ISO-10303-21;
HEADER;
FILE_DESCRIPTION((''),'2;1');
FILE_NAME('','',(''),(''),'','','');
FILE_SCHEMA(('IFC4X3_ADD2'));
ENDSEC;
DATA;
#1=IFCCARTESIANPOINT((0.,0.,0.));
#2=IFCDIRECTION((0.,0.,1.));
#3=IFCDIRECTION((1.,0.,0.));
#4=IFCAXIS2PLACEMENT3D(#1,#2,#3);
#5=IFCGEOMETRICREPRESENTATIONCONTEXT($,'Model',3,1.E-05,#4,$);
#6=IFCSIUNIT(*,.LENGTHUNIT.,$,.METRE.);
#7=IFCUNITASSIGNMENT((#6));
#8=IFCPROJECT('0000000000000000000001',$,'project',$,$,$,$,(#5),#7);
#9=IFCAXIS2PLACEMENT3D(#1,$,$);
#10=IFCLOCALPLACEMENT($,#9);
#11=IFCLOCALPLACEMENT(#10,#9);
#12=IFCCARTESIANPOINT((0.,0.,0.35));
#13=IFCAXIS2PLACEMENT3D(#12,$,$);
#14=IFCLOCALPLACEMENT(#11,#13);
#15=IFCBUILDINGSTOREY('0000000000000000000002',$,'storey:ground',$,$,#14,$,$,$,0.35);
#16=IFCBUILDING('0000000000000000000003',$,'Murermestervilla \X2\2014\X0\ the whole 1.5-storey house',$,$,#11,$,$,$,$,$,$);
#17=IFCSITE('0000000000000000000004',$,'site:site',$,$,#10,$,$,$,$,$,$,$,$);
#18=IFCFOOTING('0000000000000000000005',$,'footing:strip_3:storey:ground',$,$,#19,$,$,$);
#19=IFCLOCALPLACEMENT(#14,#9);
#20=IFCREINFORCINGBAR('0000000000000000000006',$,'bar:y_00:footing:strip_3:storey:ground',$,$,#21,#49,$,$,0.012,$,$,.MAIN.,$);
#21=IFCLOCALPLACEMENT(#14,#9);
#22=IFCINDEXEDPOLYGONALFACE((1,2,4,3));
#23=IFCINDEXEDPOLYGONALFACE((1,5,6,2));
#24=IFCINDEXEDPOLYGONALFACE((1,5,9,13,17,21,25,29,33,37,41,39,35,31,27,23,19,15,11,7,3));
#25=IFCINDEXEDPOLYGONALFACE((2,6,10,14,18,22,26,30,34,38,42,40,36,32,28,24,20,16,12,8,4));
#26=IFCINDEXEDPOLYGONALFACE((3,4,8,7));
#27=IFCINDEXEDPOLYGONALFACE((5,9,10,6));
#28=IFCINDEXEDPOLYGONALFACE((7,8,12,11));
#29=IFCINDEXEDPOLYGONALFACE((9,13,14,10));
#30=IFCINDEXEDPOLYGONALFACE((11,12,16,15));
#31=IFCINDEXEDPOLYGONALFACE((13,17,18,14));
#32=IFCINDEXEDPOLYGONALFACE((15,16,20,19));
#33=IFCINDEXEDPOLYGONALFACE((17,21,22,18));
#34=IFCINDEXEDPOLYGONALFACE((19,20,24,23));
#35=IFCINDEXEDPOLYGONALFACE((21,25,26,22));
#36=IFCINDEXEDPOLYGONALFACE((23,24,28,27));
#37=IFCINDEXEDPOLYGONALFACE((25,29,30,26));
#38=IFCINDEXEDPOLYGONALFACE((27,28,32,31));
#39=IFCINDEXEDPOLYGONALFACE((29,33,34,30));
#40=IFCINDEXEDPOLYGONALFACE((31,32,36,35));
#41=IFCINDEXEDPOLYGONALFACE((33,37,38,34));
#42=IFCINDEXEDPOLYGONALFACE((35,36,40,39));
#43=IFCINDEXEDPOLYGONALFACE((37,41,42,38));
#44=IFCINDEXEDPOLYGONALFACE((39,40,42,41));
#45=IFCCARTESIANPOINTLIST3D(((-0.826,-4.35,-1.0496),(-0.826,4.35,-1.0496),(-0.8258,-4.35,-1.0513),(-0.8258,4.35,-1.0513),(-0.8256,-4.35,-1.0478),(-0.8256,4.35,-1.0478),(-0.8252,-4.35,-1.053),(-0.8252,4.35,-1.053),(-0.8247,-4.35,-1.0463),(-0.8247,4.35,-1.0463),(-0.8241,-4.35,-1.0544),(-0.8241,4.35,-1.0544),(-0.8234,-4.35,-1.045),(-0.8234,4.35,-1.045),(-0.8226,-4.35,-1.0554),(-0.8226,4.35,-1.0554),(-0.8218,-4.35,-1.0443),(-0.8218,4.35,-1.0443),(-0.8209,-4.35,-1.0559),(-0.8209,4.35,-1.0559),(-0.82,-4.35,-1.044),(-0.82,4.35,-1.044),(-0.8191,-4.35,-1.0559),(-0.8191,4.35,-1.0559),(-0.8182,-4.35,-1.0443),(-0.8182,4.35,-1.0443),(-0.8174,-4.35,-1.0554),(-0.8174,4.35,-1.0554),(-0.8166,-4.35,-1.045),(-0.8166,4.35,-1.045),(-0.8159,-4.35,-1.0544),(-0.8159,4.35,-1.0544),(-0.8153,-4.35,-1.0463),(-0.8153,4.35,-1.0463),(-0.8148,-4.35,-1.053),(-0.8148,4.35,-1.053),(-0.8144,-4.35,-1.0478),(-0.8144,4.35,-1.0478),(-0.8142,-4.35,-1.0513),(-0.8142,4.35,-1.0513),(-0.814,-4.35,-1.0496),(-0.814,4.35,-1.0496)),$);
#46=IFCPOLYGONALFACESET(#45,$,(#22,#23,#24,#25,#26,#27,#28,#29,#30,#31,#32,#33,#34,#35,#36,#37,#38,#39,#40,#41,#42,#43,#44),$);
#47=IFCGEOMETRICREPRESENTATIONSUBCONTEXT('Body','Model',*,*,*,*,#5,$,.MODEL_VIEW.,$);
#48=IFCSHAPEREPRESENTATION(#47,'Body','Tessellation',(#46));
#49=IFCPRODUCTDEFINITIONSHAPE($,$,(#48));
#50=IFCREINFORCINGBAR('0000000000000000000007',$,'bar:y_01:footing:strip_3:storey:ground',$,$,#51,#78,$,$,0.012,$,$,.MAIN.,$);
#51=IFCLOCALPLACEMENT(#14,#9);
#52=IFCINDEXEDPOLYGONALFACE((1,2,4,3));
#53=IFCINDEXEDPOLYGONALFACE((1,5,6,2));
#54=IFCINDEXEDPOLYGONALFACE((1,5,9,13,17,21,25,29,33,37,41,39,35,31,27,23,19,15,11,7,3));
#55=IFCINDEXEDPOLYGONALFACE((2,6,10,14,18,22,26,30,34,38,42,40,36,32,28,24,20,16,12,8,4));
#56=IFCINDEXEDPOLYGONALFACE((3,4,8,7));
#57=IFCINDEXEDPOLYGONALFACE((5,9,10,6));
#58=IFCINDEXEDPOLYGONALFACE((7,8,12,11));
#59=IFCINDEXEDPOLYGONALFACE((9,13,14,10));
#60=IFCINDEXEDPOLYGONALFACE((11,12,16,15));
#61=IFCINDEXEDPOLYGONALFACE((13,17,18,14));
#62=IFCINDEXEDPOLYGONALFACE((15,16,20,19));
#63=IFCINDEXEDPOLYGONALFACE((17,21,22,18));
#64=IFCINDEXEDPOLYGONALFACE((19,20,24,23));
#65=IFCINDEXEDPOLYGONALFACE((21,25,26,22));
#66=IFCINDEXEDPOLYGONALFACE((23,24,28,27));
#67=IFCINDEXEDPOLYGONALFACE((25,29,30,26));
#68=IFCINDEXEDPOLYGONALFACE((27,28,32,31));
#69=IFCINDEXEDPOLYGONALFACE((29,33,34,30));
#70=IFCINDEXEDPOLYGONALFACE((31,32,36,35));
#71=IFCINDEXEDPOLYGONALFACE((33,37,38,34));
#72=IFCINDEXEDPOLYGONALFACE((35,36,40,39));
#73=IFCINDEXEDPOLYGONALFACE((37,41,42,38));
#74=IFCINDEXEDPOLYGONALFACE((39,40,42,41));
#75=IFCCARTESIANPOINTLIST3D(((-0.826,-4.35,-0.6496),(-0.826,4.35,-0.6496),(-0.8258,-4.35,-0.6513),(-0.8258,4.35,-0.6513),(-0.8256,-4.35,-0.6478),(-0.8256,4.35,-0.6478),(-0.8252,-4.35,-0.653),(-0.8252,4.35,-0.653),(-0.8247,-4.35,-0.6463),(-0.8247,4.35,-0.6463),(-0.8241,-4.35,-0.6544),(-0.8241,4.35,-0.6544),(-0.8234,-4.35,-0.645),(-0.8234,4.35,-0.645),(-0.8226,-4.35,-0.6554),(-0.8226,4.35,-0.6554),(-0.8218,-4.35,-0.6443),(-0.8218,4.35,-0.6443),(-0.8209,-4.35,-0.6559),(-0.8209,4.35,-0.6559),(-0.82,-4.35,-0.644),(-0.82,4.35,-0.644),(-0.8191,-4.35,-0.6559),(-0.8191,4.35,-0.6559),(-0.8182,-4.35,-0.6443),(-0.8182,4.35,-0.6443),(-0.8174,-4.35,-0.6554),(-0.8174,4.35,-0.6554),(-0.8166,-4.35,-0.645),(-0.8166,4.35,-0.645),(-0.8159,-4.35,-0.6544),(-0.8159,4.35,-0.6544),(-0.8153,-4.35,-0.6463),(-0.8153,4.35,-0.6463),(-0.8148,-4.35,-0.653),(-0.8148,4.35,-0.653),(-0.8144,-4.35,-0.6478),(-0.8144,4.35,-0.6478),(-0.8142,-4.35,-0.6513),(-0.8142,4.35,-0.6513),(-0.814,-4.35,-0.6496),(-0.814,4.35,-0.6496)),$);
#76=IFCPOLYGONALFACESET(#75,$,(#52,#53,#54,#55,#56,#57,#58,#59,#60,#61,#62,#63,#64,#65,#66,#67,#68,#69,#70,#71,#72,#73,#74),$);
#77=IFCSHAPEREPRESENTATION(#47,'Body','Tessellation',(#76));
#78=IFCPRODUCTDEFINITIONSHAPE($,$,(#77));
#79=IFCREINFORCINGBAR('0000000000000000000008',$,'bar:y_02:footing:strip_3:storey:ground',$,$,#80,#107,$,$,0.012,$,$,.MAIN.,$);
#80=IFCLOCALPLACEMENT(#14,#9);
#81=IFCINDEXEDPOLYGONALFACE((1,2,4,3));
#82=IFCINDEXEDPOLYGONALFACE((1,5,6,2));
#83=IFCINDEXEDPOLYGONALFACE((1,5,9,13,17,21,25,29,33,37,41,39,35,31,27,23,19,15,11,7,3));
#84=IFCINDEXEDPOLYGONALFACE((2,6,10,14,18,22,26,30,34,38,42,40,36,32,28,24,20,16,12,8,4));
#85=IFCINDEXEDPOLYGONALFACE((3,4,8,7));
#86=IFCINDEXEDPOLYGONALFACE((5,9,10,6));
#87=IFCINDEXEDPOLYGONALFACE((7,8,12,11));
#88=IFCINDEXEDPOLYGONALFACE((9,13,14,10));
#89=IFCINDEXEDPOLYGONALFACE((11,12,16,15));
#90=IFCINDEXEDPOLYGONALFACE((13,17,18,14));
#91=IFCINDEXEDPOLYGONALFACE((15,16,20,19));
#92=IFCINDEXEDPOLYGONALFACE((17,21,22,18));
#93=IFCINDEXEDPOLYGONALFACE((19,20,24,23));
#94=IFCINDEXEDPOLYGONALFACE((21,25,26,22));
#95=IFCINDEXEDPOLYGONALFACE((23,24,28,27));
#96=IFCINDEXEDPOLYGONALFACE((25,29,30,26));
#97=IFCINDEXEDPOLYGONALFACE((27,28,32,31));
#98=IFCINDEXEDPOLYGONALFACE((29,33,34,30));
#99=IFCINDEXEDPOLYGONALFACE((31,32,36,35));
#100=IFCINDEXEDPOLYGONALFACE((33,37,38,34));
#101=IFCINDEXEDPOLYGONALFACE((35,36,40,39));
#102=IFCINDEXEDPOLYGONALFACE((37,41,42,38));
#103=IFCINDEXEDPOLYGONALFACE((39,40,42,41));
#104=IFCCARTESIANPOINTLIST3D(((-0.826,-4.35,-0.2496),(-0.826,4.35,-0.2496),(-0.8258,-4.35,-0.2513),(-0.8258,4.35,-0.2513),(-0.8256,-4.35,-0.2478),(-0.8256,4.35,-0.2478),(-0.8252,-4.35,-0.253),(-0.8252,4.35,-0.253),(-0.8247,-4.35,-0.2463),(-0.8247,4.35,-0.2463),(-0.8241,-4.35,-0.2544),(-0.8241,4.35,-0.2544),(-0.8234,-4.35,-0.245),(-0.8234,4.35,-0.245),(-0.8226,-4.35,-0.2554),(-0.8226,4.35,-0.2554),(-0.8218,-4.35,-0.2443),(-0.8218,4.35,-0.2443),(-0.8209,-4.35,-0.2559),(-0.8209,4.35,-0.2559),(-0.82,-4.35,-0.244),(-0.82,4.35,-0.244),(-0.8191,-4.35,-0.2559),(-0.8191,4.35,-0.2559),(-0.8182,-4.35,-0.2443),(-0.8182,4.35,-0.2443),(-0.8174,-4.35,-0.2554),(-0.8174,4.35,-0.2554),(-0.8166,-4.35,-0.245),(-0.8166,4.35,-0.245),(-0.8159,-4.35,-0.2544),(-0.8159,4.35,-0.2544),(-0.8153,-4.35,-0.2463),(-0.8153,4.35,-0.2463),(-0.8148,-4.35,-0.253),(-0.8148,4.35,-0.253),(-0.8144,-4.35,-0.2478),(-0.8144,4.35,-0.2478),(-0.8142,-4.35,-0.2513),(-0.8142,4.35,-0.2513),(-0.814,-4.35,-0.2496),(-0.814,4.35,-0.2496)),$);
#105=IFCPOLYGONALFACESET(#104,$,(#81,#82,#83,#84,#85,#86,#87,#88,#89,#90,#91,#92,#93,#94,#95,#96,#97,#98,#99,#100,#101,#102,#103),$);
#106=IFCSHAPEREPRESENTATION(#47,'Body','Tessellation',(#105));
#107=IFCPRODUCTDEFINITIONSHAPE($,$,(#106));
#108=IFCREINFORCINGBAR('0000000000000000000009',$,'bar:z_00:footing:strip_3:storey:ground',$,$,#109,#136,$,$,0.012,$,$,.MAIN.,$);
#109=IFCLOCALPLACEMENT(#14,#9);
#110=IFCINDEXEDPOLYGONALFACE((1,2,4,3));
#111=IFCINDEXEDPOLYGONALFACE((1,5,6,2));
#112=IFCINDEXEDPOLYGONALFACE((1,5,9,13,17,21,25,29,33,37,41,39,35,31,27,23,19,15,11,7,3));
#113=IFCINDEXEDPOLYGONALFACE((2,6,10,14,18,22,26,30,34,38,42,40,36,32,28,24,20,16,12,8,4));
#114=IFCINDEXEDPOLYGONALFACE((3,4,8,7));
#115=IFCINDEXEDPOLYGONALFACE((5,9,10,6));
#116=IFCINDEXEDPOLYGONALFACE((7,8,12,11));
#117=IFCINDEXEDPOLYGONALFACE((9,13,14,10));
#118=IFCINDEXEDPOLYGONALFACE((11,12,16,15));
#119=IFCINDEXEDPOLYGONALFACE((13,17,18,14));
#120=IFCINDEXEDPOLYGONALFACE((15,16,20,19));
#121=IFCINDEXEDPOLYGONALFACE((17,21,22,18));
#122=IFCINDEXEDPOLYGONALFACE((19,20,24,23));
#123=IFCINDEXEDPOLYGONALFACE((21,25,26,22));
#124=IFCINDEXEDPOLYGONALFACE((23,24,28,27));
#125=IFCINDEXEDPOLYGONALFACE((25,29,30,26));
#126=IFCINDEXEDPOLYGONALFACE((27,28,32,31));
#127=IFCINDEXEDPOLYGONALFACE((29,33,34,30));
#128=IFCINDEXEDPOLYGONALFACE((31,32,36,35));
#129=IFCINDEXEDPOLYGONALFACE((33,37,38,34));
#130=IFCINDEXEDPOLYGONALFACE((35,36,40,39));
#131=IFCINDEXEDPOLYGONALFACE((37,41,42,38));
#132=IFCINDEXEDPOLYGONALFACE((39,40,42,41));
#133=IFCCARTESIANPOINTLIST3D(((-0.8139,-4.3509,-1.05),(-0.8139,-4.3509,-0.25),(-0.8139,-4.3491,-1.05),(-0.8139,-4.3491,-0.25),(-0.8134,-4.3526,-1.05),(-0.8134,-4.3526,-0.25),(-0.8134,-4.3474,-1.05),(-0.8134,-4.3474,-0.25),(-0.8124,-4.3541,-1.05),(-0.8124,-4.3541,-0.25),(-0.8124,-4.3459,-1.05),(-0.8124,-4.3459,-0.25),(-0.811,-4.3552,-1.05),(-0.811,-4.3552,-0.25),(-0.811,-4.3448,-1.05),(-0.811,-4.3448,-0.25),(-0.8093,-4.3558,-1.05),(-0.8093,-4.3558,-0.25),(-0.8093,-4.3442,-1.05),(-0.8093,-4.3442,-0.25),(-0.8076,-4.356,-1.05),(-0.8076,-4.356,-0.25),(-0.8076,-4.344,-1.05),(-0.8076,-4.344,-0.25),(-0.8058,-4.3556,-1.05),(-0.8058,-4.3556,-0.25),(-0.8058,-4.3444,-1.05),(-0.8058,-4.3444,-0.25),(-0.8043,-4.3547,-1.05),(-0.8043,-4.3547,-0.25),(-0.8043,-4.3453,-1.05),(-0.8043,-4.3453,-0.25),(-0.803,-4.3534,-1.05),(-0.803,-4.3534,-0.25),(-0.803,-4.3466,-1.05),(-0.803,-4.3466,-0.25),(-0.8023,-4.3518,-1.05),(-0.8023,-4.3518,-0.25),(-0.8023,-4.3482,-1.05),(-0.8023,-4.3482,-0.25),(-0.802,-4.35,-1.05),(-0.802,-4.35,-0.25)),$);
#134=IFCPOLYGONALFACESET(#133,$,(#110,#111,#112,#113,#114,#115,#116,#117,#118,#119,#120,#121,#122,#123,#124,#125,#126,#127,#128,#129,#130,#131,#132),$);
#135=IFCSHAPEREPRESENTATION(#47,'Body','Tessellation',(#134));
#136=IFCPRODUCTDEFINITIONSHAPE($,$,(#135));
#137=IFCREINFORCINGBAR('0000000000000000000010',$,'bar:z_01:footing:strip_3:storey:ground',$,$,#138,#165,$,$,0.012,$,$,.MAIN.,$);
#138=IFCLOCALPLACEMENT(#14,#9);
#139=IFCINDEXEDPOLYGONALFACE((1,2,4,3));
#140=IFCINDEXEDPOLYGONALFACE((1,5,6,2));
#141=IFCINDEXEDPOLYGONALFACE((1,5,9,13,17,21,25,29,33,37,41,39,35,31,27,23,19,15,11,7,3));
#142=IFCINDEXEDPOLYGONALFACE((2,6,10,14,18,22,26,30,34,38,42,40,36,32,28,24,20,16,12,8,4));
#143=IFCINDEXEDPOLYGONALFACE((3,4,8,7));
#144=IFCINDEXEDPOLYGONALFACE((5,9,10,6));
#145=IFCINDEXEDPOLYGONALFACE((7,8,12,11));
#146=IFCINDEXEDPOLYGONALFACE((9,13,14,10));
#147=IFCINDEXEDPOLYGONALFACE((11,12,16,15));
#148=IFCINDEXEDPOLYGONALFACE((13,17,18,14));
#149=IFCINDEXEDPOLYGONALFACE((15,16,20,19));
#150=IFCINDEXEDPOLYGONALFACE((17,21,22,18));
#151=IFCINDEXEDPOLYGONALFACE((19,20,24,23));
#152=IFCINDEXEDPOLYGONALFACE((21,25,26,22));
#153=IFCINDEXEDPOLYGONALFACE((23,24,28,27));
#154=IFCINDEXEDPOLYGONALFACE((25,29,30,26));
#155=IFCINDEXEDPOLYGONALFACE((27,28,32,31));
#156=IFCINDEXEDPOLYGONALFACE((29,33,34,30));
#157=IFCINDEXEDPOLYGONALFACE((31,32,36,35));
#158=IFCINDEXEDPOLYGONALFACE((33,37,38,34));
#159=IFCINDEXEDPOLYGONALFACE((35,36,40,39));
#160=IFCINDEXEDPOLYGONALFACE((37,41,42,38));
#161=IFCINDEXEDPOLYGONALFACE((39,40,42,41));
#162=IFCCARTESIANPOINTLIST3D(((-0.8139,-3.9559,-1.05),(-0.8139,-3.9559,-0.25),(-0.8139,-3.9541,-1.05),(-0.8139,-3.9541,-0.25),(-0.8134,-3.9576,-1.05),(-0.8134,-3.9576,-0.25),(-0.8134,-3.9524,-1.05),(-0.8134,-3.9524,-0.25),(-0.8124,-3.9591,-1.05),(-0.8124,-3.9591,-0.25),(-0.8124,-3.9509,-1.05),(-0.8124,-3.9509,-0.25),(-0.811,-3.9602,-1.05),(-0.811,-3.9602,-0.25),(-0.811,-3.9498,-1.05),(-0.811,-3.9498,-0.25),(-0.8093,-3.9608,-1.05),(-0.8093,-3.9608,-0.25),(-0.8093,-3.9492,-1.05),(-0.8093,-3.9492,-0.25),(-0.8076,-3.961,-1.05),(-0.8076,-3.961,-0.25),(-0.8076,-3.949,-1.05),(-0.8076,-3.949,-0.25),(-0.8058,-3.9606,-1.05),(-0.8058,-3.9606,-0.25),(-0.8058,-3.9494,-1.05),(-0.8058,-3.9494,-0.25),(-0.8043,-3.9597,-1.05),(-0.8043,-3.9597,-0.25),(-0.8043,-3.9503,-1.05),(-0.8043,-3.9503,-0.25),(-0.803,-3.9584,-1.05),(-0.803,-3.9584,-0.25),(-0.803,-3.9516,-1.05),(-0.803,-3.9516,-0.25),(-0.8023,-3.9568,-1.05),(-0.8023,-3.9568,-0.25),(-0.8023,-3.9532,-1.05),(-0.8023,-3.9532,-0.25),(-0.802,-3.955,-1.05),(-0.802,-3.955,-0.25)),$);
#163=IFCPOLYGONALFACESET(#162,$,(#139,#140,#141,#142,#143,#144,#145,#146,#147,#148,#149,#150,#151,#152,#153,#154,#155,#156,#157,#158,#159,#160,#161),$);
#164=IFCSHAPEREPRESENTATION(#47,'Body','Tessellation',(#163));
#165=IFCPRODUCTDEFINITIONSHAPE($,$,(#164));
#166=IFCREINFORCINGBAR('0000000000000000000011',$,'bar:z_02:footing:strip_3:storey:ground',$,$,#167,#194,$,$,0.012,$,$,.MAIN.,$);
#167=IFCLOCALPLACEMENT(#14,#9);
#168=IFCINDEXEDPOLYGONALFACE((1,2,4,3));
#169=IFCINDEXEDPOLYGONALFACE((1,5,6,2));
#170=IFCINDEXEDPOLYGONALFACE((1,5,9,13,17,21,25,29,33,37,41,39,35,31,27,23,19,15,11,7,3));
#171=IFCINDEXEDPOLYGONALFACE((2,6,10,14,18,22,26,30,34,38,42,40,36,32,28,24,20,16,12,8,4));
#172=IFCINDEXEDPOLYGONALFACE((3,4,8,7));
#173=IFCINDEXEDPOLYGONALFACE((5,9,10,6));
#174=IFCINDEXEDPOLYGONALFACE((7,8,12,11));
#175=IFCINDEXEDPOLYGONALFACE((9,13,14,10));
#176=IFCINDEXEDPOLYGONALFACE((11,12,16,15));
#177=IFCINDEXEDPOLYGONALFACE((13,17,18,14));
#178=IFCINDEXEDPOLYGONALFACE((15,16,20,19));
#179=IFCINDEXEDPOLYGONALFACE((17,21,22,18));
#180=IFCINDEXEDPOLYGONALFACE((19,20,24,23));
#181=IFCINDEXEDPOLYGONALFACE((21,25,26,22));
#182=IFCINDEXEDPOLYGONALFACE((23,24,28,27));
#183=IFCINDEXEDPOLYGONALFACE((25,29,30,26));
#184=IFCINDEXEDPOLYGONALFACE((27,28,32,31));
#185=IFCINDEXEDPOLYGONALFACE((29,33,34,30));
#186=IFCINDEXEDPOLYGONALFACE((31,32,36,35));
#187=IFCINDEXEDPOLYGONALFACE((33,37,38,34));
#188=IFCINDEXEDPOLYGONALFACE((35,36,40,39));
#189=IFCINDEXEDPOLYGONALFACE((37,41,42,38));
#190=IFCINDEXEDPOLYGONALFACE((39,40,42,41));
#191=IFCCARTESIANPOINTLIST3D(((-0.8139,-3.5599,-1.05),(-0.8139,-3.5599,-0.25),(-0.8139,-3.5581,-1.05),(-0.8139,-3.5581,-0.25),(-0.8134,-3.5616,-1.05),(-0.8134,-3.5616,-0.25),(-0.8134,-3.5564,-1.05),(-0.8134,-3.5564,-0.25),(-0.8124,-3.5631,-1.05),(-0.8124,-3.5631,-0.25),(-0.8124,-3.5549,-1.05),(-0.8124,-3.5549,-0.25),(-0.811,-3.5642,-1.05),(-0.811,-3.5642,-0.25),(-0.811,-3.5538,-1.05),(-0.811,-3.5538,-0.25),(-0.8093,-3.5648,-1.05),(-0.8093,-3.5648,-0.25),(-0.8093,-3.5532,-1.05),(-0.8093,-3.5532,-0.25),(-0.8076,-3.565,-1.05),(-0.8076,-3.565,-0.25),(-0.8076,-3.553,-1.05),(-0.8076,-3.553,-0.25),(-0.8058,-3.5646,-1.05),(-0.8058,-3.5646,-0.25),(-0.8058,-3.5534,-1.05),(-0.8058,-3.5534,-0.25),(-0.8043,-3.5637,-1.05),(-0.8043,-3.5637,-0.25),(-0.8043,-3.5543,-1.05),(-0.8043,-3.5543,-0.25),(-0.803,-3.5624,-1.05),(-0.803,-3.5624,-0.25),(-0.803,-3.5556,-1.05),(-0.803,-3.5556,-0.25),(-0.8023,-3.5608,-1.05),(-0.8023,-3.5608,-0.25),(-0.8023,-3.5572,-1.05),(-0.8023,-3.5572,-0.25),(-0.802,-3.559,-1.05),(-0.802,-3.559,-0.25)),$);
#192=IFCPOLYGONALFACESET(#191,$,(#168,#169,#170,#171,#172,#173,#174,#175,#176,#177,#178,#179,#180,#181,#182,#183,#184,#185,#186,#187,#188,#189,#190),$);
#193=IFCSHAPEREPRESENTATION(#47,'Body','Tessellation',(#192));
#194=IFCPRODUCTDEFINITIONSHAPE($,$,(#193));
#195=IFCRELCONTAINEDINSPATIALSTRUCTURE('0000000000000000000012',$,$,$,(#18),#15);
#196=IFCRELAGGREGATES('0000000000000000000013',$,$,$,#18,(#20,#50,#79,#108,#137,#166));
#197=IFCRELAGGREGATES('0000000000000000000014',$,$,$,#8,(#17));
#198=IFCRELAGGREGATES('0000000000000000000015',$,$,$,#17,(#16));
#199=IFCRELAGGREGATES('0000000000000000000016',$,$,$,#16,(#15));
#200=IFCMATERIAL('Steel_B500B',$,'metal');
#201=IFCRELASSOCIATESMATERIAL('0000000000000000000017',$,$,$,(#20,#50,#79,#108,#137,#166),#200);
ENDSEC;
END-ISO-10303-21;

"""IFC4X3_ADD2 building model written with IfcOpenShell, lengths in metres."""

from ifc_helpers import new_model, entity, si_unit, frame, origin, origin_with_axes, place, context, subcontext, project, spatial, material, element, aggregate, save


model = new_model("IFC4X3_ADD2")

# Units and contexts
model_context = context("Model", 3, precision=1e-05, world=origin_with_axes())
body_context = subcontext(model_context, "Body", "Model", "MODEL_VIEW")
ifc_project = project(units=[si_unit("LENGTHUNIT", "METRE")], contexts=[model_context])

# Site, building, storey
placement_1 = place(None, origin())
site = spatial("IfcSite", under=ifc_project, at=placement_1, Name="site:site")
building_placement = place(placement_1, origin())
building = spatial("IfcBuilding", under=site, at=building_placement, Name="Murermestervilla — the whole 1.5-storey house")
storey_placement = place(building_placement, frame((0.0, 0.0, 0.35)))
storey = spatial("IfcBuildingStorey", under=building, at=storey_placement, Name="storey:ground", Elevation=0.35)

# Footing, reinforcing bars
placement_2 = place(storey_placement, frame((0.0, 0.0, -0.35)))
ifc_material = material(Name="Steel_B500B", Category="metal")
footing_1 = element("IfcFooting", 1, at=placement_2, inside=storey, Name="footing:strip_3:storey:ground")
reinforcing_bar_1 = element("IfcReinforcingBar", 2, at=placement_1, material=ifc_material, Name="bar:y_00:footing:strip_3:storey:ground", NominalDiameter=0.012, PredefinedType="MAIN", context=body_context, shape_type="AdvancedSweptSolid", body=[
    entity("IfcSweptDiskSolid", entity("IfcPolyline", [entity("IfcCartesianPoint", [-0.82, -4.35, -0.7]), entity("IfcCartesianPoint", [-0.82, 4.35, -0.7])]), 0.006),
])
reinforcing_bar_2 = element("IfcReinforcingBar", 3, at=placement_1, material=ifc_material, Name="bar:y_01:footing:strip_3:storey:ground", NominalDiameter=0.012, PredefinedType="MAIN", context=body_context, shape_type="AdvancedSweptSolid", body=[
    entity("IfcSweptDiskSolid", entity("IfcPolyline", [entity("IfcCartesianPoint", [-0.82, -4.35, -0.3]), entity("IfcCartesianPoint", [-0.82, 4.35, -0.3])]), 0.006),
])
reinforcing_bar_3 = element("IfcReinforcingBar", 4, at=placement_1, material=ifc_material, Name="bar:y_02:footing:strip_3:storey:ground", NominalDiameter=0.012, PredefinedType="MAIN", context=body_context, shape_type="AdvancedSweptSolid", body=[
    entity("IfcSweptDiskSolid", entity("IfcPolyline", [entity("IfcCartesianPoint", [-0.82, -4.35, 0.1]), entity("IfcCartesianPoint", [-0.82, 4.35, 0.1])]), 0.006),
])
reinforcing_bar_4 = element("IfcReinforcingBar", 5, at=placement_1, material=ifc_material, Name="bar:z_00:footing:strip_3:storey:ground", NominalDiameter=0.012, PredefinedType="MAIN", context=body_context, shape_type="AdvancedSweptSolid", body=[
    entity("IfcSweptDiskSolid", entity("IfcPolyline", [entity("IfcCartesianPoint", [-0.808, -4.35, -0.7]), entity("IfcCartesianPoint", [-0.808, -4.35, 0.1])]), 0.006),
])
reinforcing_bar_5 = element("IfcReinforcingBar", 6, at=placement_1, material=ifc_material, Name="bar:z_01:footing:strip_3:storey:ground", NominalDiameter=0.012, PredefinedType="MAIN", context=body_context, shape_type="AdvancedSweptSolid", body=[
    entity("IfcSweptDiskSolid", entity("IfcPolyline", [entity("IfcCartesianPoint", [-0.808, -3.955, -0.7]), entity("IfcCartesianPoint", [-0.808, -3.955, 0.1])]), 0.006),
])
reinforcing_bar_6 = element("IfcReinforcingBar", 7, at=placement_1, material=ifc_material, Name="bar:z_02:footing:strip_3:storey:ground", NominalDiameter=0.012, PredefinedType="MAIN", context=body_context, shape_type="AdvancedSweptSolid", body=[
    entity("IfcSweptDiskSolid", entity("IfcPolyline", [entity("IfcCartesianPoint", [-0.808, -3.559, -0.7]), entity("IfcCartesianPoint", [-0.808, -3.559, 0.1])]), 0.006),
])
aggregate(footing_1, [reinforcing_bar_1, reinforcing_bar_2, reinforcing_bar_3, reinforcing_bar_4, reinforcing_bar_5, reinforcing_bar_6])

save(model, "model.ifc")
